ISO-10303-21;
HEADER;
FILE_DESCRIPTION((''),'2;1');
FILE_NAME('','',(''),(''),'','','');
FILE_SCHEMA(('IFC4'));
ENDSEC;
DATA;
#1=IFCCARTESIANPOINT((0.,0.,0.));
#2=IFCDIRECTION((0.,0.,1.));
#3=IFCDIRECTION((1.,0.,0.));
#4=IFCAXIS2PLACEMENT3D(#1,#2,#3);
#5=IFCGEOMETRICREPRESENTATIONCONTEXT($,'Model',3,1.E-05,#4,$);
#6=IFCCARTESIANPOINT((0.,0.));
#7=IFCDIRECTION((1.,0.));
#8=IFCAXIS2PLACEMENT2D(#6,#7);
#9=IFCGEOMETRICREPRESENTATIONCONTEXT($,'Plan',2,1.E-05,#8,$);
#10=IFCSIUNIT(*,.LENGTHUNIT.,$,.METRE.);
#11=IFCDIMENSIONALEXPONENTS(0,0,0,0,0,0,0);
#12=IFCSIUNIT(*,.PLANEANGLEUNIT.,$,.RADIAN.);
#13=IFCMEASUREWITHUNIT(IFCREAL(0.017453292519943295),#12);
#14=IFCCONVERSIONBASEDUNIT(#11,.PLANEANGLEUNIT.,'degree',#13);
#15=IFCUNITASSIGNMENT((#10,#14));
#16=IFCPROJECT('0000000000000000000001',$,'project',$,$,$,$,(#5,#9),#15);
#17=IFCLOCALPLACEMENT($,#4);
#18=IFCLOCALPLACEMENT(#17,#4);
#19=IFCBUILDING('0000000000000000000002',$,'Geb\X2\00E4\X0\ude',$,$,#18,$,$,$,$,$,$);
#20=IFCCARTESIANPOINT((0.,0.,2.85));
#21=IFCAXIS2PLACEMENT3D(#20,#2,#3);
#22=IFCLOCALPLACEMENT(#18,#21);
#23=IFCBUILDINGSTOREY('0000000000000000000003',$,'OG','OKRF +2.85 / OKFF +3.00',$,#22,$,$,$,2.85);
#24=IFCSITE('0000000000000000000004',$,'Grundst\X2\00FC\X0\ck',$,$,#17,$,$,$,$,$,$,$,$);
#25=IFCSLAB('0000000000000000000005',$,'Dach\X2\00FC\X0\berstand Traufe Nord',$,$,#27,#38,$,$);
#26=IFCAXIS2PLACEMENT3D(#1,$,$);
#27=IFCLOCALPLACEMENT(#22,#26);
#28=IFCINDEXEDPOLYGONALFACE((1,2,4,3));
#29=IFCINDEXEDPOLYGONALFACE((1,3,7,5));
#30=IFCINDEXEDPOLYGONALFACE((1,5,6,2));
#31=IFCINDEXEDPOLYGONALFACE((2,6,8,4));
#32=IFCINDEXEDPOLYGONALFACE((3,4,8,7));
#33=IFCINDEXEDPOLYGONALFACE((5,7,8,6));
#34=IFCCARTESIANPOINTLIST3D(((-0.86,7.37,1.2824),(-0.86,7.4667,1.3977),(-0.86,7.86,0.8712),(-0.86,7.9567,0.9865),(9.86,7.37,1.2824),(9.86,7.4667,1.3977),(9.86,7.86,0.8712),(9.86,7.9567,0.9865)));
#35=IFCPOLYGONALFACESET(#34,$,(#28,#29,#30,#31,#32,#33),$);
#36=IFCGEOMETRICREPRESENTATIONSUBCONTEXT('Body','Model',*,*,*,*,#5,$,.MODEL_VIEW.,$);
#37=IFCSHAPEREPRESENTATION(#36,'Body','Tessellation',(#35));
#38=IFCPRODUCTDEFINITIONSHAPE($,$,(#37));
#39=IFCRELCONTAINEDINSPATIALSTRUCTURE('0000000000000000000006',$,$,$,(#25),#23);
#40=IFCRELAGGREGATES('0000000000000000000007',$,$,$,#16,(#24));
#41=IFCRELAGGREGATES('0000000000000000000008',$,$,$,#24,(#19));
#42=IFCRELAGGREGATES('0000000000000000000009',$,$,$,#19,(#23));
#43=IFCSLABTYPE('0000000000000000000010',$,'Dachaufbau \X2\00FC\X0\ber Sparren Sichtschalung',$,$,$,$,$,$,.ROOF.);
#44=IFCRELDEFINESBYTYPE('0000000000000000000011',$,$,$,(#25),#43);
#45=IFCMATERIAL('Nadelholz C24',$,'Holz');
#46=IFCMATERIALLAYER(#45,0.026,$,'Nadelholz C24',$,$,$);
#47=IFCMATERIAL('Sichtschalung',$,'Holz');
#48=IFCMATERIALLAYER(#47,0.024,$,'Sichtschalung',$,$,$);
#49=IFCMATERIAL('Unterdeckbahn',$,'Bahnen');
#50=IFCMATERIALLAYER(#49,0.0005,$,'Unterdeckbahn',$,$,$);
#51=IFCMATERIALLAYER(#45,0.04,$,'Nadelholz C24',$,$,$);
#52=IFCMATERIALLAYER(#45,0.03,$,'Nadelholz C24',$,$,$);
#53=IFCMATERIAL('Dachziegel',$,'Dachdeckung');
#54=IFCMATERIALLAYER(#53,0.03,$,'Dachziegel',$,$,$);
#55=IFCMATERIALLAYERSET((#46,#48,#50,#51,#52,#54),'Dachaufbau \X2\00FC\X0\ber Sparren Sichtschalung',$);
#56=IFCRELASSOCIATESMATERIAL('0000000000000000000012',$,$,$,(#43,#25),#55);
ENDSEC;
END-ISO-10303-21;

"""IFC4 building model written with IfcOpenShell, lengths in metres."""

from ifc_helpers import new_model, entity, si_unit, converted_unit, frame, origin_with_axes, origin_2d_with_axis, place, context, subcontext, project, spatial, indexed_curve, outline, extrude, clip, halfspace, material, layer, layer_set, layer_usage, type_object, element, save


model = new_model("IFC4")

# Units and contexts
model_context = context("Model", 3, precision=1e-05, world=origin_with_axes())
plan_context = context("Plan", 2, precision=1e-05, world=origin_2d_with_axis())
body_context = subcontext(model_context, "Body", "Model", "MODEL_VIEW")
ifc_project = project(units=[si_unit("LENGTHUNIT", "METRE"), converted_unit("PLANEANGLEUNIT", "degree", entity("IfcReal", 0.017453292519943295), si_unit("PLANEANGLEUNIT", "RADIAN"), dimensions=[0, 0, 0, 0, 0, 0, 0])], contexts=[model_context, plan_context])

# Site, building, storey
site_placement = place(None, origin_with_axes())
site = spatial("IfcSite", under=ifc_project, at=site_placement, Name="Grundstück")
building_placement = place(site_placement, origin_with_axes())
building = spatial("IfcBuilding", under=site, at=building_placement, Name="Gebäude")
storey_placement = place(building_placement, frame((0.0, 0.0, 2.85), z_axis=(0.0, 0.0, 1.0), x_axis=(1.0, 0.0, 0.0)))
storey = spatial("IfcBuildingStorey", under=building, at=storey_placement, Name="OG", Description="OKRF +2.85 / OKFF +3.00", Elevation=2.85)

# Shared definitions
ifc_material_1 = material(Name="Nadelholz C24", Category="Holz")

# Slab
ifc_material_2 = material(Name="Unterdeckbahn", Category="Bahnen")
ifc_material_3 = material(Name="Dachziegel", Category="Dachdeckung")
ifc_layer_1 = layer(ifc_material_1, 0.026, Name="Nadelholz C24")
ifc_material_4 = material(Name="Sichtschalung", Category="Holz")
ifc_layer_2 = layer(ifc_material_4, 0.024, Name="Sichtschalung")
ifc_layer_3 = layer(ifc_material_2, 0.0005, Name="Unterdeckbahn")
ifc_layer_4 = layer(ifc_material_1, 0.04, Name="Nadelholz C24")
ifc_layer_5 = layer(ifc_material_1, 0.03, Name="Nadelholz C24")
ifc_layer_6 = layer(ifc_material_3, 0.03, Name="Dachziegel")
ifc_layer_set_1 = layer_set([ifc_layer_1, ifc_layer_2, ifc_layer_3, ifc_layer_4, ifc_layer_5, ifc_layer_6], Name="Dachaufbau über Sparren Sichtschalung")
ifc_layer_usage_1 = layer_usage(ifc_layer_set_1, "AXIS3", "POSITIVE", 0.0)
slab_type_1 = type_object("IfcSlabType", Name="Dachaufbau über Sparren Sichtschalung", PredefinedType="ROOF", material=ifc_layer_set_1)
slab_1_placement = place(storey_placement, frame((9.86, 7.86, 0.8712), z_axis=(0.0, 0.642788, 0.766044), x_axis=(-1.0, 0.0, 0.0)))
element("IfcSlab", 1, at=slab_1_placement, inside=storey, type_object=slab_type_1, material=ifc_layer_usage_1, Name="Dachüberstand Traufe Nord", context=body_context, shape_type="Clipping", body=[
    clip(extrude(outline(indexed_curve([(10.72, 0.6396), (0.0, 0.6396), (0.0, 0.0), (10.72, 0.0)])), None, (0.0, 0.0, 1.0), 0.1505), halfspace(frame((9.86, 0.948, -5.6532), z_axis=(0.0, 0.766044, -0.642788), x_axis=(1.0, 0.0, 0.0)), False)),
])

save(model, "model.ifc")
